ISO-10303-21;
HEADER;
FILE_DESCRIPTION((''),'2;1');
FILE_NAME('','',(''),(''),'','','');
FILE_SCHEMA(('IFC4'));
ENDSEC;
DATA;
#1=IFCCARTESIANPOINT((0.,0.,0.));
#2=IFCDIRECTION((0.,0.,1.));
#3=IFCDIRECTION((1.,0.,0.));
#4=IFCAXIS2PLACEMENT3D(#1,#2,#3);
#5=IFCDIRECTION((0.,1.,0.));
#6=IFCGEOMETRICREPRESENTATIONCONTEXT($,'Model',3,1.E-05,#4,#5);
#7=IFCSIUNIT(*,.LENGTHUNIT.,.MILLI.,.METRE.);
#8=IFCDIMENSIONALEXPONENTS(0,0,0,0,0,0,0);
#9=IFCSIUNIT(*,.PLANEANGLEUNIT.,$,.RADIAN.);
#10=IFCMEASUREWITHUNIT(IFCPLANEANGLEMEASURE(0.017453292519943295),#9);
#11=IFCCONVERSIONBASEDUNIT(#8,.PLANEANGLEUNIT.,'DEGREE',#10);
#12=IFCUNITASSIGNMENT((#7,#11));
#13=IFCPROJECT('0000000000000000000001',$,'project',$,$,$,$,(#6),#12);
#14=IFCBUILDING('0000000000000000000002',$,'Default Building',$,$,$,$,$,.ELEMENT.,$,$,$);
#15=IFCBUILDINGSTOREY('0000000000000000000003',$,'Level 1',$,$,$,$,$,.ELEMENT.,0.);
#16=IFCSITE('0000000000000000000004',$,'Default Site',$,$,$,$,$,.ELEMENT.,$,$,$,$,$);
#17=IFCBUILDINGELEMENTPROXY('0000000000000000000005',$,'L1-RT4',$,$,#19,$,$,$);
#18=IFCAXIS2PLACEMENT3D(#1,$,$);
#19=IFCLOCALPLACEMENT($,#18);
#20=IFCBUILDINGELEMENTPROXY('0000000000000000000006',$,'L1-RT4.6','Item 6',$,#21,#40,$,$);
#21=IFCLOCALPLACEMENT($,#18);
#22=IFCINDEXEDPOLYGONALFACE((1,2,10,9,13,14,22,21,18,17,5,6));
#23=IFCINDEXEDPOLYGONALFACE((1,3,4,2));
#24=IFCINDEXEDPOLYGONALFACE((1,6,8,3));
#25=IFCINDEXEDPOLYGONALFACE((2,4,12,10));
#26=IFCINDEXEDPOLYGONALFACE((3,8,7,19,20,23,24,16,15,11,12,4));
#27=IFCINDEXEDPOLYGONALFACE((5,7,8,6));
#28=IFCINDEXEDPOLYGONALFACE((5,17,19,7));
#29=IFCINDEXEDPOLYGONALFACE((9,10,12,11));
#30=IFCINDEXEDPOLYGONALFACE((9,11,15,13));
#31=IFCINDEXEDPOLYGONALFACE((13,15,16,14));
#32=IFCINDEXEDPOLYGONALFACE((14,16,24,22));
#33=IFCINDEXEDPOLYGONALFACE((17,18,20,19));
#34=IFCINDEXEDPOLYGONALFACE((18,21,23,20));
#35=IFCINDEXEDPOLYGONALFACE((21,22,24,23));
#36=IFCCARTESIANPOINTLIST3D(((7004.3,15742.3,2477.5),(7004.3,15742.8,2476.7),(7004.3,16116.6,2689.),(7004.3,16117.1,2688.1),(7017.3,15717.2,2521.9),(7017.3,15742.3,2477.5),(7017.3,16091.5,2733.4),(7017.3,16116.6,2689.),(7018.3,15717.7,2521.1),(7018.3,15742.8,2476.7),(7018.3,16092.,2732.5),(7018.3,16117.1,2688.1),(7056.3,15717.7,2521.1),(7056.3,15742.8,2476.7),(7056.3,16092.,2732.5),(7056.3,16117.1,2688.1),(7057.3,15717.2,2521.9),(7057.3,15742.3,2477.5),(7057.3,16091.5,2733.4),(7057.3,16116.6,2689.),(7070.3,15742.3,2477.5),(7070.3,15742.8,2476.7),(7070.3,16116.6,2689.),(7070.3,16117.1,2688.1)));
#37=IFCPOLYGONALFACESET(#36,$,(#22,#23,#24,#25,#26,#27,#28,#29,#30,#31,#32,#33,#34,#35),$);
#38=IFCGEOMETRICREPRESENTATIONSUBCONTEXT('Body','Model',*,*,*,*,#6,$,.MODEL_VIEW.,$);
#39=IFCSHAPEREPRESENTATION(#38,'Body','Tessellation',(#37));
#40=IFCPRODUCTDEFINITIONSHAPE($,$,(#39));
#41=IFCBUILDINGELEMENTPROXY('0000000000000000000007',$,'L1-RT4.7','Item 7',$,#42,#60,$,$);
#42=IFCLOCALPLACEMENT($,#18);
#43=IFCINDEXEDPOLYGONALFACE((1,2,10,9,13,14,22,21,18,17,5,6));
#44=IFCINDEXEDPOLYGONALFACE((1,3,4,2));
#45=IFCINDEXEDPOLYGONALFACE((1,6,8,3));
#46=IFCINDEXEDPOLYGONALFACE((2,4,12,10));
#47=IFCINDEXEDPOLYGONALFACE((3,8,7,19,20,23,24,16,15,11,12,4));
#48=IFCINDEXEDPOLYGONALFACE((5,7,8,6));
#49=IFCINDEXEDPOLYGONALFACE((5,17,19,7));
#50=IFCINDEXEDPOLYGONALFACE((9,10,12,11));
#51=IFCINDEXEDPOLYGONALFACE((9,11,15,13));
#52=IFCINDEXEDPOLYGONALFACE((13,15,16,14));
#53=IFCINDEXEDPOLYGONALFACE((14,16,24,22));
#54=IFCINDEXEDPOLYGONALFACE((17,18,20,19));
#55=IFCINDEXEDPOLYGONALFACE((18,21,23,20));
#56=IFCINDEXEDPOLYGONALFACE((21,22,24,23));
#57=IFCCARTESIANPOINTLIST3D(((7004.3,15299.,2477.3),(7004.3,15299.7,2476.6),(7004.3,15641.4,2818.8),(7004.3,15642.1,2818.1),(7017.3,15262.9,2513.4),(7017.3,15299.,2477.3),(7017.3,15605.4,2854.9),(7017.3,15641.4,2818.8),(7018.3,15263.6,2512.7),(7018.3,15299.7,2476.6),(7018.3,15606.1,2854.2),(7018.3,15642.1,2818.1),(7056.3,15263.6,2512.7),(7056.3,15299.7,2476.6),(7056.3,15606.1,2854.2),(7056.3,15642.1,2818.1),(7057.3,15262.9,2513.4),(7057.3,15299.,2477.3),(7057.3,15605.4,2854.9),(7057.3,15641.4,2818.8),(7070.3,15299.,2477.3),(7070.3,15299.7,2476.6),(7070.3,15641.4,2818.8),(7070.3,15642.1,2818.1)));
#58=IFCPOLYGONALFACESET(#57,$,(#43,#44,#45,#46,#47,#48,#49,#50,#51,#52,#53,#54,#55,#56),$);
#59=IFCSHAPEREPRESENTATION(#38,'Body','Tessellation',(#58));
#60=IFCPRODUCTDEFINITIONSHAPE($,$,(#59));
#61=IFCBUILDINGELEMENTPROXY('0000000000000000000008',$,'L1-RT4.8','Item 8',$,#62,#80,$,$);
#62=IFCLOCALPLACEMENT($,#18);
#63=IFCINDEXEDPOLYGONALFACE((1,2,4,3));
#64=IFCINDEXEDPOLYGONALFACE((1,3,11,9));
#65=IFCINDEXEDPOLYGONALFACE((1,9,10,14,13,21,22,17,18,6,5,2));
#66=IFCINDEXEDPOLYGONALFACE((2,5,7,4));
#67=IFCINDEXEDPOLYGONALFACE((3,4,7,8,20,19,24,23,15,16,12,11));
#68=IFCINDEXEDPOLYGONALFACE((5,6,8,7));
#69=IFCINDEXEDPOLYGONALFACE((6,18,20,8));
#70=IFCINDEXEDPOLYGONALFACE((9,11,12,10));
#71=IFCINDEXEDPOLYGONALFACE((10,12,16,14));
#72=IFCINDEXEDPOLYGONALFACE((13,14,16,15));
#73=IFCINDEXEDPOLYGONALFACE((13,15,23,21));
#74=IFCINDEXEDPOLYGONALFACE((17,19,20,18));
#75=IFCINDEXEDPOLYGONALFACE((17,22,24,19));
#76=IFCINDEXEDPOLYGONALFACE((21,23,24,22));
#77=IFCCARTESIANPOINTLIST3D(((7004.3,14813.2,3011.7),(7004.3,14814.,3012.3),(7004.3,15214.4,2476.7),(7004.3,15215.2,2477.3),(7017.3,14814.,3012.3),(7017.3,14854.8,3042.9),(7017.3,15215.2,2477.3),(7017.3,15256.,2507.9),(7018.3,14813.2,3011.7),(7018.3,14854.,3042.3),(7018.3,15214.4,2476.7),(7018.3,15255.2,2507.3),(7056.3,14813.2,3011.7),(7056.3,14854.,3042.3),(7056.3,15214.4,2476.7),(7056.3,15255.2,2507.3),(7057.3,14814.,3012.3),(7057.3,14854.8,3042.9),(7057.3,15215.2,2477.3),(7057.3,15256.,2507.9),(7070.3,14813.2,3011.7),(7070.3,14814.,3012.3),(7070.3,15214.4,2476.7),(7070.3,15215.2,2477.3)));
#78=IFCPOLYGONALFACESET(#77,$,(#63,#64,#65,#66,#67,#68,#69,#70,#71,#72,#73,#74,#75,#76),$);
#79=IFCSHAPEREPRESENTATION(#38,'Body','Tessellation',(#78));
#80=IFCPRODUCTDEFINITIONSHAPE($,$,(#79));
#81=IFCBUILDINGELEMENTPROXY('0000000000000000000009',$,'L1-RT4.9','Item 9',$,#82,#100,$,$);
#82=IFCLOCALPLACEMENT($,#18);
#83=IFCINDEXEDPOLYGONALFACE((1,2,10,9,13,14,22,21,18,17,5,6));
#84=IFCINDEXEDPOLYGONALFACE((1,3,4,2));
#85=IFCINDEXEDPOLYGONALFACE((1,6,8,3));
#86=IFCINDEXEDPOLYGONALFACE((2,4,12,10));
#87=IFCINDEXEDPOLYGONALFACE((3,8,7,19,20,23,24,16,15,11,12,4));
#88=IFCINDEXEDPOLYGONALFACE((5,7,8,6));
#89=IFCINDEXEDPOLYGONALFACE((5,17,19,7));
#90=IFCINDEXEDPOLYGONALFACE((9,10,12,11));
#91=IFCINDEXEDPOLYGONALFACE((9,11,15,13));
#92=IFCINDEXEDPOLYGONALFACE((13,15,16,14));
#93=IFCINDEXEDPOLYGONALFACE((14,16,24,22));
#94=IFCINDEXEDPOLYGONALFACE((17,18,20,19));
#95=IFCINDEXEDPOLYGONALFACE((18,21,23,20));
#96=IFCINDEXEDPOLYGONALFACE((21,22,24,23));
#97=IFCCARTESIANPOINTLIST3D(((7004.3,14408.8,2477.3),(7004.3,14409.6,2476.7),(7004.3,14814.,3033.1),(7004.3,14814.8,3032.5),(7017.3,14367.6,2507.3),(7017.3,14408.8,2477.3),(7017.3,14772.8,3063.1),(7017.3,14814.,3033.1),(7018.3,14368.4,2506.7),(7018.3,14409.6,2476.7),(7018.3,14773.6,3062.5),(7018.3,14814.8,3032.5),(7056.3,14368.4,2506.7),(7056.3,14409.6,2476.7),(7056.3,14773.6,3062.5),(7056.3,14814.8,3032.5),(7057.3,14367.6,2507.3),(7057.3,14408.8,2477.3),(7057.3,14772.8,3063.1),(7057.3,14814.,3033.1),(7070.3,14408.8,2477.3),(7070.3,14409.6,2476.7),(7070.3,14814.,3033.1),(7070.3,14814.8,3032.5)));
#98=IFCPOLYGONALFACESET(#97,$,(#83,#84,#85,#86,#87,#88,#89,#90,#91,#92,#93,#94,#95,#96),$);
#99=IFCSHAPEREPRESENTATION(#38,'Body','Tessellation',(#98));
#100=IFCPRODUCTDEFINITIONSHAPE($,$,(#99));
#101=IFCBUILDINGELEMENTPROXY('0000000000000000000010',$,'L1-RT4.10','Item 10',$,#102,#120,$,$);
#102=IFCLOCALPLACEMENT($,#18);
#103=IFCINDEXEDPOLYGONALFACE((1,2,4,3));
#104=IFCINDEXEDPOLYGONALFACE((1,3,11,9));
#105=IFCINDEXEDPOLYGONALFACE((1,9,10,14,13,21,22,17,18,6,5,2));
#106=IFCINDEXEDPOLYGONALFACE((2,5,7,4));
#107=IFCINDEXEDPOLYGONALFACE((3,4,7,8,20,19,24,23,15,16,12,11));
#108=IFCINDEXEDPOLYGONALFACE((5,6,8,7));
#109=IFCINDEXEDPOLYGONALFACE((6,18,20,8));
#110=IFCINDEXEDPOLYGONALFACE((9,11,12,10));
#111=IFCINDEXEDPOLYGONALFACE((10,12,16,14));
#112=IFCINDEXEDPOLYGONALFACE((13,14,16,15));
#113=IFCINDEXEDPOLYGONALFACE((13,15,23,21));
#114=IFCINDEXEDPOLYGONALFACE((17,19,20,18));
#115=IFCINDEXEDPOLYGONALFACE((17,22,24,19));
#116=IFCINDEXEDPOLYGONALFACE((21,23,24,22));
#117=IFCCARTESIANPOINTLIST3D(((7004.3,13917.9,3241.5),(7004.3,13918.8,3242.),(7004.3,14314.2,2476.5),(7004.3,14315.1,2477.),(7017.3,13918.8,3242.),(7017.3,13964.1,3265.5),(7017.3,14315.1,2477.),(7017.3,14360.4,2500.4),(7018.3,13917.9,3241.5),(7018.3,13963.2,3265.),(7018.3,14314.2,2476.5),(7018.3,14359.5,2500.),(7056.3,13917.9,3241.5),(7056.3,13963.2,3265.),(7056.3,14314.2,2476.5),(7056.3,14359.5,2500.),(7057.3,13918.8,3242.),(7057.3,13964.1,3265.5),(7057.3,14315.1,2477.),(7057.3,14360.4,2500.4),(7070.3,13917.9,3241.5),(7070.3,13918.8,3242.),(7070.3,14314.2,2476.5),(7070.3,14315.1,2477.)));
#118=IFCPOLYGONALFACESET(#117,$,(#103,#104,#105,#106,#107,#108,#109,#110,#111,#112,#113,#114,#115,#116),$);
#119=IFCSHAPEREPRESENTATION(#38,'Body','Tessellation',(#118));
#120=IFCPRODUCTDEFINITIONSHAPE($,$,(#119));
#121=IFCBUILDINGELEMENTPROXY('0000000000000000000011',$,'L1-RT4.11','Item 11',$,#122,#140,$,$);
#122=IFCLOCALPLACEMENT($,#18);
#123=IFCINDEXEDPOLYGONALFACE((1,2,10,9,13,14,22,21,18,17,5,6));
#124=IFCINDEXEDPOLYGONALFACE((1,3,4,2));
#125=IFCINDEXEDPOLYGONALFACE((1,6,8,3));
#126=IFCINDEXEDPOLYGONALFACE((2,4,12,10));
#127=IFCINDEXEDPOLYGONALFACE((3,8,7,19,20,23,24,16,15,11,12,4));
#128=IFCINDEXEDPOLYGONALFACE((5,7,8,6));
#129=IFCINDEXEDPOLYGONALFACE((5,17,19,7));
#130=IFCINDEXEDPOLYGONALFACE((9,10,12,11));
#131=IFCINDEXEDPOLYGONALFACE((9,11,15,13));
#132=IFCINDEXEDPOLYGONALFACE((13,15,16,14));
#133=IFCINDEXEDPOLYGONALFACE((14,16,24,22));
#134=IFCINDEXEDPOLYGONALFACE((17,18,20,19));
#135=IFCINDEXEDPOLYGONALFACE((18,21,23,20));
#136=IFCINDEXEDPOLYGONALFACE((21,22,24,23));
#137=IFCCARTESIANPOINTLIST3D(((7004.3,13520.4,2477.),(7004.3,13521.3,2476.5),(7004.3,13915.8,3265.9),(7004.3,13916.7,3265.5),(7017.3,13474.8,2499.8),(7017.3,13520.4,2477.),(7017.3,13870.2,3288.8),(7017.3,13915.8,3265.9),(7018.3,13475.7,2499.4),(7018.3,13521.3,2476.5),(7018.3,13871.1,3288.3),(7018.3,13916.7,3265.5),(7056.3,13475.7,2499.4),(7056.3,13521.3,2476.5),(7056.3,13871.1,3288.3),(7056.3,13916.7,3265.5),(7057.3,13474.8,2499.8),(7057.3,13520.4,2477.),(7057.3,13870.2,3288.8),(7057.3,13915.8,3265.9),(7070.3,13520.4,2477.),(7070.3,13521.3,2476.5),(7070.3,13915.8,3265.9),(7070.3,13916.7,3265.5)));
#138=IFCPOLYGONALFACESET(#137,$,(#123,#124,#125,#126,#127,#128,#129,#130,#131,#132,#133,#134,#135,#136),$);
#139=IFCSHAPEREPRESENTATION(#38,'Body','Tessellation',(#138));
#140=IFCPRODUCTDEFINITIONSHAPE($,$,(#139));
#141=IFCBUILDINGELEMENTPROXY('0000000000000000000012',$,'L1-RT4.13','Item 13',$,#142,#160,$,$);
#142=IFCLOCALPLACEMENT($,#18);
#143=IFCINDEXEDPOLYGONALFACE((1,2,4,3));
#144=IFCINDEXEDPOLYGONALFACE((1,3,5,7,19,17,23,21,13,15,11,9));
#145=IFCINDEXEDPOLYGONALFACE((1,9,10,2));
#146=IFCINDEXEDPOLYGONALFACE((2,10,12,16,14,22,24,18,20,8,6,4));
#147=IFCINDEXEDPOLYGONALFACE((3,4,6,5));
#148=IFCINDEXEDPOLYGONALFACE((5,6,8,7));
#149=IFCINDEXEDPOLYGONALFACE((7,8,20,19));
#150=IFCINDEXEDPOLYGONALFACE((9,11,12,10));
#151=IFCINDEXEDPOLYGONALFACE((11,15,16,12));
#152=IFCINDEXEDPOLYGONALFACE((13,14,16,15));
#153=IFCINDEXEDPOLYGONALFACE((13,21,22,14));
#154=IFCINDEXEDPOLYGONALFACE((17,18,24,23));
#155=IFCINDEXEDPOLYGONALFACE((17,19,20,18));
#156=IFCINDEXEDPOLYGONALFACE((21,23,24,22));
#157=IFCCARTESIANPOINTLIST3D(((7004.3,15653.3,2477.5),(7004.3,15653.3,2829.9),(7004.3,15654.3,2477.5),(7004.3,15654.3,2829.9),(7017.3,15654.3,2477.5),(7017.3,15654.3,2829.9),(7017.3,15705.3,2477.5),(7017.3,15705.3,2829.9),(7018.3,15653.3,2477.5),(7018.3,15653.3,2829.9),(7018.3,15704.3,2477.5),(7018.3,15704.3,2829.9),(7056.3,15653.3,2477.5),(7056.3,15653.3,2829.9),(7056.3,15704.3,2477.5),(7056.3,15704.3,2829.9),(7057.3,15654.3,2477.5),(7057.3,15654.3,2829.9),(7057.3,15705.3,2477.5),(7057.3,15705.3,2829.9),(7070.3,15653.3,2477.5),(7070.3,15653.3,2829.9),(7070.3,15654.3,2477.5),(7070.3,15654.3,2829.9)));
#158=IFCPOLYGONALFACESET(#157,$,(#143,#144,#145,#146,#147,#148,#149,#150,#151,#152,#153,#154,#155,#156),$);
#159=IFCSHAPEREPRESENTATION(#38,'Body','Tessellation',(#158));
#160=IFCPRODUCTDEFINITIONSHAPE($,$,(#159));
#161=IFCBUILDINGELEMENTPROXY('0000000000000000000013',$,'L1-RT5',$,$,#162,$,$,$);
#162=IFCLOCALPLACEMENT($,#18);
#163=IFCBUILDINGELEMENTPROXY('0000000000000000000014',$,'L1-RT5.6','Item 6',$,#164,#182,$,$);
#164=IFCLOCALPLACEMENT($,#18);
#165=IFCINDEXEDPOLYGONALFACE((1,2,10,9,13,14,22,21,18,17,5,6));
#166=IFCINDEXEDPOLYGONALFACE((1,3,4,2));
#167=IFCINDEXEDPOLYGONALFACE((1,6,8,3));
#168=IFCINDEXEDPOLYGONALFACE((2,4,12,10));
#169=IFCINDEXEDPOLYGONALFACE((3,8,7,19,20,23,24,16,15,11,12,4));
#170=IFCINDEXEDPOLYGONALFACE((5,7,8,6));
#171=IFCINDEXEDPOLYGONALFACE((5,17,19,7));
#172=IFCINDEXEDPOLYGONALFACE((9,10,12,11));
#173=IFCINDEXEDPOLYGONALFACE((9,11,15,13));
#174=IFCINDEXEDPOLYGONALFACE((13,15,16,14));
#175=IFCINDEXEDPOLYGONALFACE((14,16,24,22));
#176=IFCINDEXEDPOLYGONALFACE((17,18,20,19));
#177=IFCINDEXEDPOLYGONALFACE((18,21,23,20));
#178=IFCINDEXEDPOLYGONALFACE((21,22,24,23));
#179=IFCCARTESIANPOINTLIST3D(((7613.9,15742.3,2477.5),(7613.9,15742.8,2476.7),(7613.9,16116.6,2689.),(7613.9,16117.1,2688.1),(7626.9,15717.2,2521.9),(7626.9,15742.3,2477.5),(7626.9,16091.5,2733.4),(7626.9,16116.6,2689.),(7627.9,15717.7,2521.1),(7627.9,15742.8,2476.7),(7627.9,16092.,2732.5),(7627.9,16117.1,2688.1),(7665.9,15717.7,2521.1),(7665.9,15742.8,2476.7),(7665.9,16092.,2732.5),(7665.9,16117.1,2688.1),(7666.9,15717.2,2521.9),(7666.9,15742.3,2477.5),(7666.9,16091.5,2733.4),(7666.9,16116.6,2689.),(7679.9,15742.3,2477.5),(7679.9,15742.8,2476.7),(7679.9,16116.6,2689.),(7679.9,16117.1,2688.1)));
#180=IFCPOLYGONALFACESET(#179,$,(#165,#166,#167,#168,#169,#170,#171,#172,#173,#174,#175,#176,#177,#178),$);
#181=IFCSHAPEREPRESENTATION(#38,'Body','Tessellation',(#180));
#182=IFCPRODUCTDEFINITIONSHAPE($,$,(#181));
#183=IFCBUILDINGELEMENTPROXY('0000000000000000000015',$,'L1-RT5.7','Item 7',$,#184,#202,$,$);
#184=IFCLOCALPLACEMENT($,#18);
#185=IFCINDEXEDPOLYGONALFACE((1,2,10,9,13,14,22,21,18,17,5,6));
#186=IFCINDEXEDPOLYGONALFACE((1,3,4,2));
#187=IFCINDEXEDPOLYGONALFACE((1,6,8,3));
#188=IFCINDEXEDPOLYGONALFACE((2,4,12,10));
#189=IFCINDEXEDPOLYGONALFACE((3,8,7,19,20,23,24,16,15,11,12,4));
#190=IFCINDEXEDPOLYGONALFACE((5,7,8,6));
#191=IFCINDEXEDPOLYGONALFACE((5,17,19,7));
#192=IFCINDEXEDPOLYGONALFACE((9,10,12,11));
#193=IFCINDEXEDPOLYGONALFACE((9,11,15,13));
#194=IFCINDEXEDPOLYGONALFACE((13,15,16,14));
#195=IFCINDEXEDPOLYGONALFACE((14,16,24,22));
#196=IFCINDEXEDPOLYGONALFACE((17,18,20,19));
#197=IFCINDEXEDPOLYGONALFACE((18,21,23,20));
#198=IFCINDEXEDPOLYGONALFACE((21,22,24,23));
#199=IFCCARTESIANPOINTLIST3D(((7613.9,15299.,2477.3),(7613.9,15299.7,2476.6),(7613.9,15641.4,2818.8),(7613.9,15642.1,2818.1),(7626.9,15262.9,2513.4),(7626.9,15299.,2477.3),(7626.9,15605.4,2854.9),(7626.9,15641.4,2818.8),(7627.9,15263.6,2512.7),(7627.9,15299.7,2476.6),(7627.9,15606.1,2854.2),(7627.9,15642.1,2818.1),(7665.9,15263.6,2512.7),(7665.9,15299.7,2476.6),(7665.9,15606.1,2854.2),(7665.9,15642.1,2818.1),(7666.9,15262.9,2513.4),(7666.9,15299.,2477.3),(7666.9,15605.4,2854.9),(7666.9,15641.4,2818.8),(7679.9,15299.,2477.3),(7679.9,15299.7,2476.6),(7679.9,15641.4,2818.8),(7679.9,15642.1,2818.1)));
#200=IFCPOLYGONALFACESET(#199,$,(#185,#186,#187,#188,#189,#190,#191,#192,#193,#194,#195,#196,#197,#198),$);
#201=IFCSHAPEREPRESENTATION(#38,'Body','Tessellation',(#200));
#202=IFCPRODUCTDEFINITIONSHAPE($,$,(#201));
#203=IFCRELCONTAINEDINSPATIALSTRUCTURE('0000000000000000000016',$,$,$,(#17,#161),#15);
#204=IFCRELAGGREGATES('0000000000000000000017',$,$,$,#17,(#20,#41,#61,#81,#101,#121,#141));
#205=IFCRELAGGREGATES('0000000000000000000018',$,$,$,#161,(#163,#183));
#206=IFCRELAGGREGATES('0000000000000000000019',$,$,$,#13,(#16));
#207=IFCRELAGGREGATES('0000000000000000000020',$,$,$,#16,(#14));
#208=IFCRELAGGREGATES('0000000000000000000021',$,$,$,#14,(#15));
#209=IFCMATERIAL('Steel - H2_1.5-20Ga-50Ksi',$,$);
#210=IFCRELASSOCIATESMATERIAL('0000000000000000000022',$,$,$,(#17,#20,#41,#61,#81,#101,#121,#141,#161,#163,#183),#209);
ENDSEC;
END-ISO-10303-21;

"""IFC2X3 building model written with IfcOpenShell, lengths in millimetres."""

from ifc_helpers import new_model, entity, si_unit, converted_unit, direction, frame, origin, origin_with_axes, place, context, subcontext, project, spatial, polyline, outline, extrude, material, element, aggregate, save


model = new_model("IFC2X3")

# Units and contexts
model_context = context("Model", 3, precision=1e-05, world=origin_with_axes(), true_north=direction((0.0, 1.0, 0.0)))
body_context = subcontext(model_context, "Body", "Model", "MODEL_VIEW")
ifc_project = project(units=[si_unit("LENGTHUNIT", "METRE", prefix="MILLI"), converted_unit("PLANEANGLEUNIT", "DEGREE", entity("IfcPlaneAngleMeasure", 0.017453292519943295), si_unit("PLANEANGLEUNIT", "RADIAN"), dimensions=[0, 0, 0, 0, 0, 0, 0])], contexts=[model_context])

# Site, building, storey
site = spatial("IfcSite", under=ifc_project, Name="Default Site", CompositionType="ELEMENT")
building = spatial("IfcBuilding", under=site, Name="Default Building", CompositionType="ELEMENT")
storey = spatial("IfcBuildingStorey", under=building, Name="Level 1", CompositionType="ELEMENT", Elevation=0.0)

# Building element proxies
ifc_material = material(Name="Steel - H2_1.5-20Ga-50Ksi")
proxy_1 = element("IfcBuildingElementProxy", 1, inside=storey, material=ifc_material, Name="L1-RT4")
proxy_2_placement = place(None, frame((7004.3, 16117.1, 2688.1), z_axis=(0.0, -0.871, -0.492), x_axis=(40.0, 0.0, 0.0)))
proxy_2 = element("IfcBuildingElementProxy", 2, at=proxy_2_placement, material=ifc_material, Name="L1-RT4.6", Description="Item 6", context=body_context, shape_type="SweptSolid", body=[
    extrude(outline(polyline([(0.0, 0.0), (14.0, 0.0), (14.0, 51.0), (52.0, 51.0), (52.0, 0.0), (66.0, 0.0), (66.0, 1.0), (53.0, 1.0), (53.0, 52.0), (13.0, 52.0), (13.0, 1.0), (0.0, 1.0), (0.0, 0.0)])), origin(), (0.0, 0.0, 1.0), 429.9),
])
proxy_3_placement = place(None, frame((7004.3, 15642.1, 2818.1), z_axis=(0.0, -0.708, -0.706), x_axis=(40.0, 0.0, 0.0)))
proxy_3 = element("IfcBuildingElementProxy", 3, at=proxy_3_placement, material=ifc_material, Name="L1-RT4.7", Description="Item 7", context=body_context, shape_type="SweptSolid", body=[
    extrude(outline(polyline([(0.0, 0.0), (14.0, 0.0), (14.0, 51.0), (52.0, 51.0), (52.0, 0.0), (66.0, 0.0), (66.0, 1.0), (53.0, 1.0), (53.0, 52.0), (13.0, 52.0), (13.0, 1.0), (0.0, 1.0), (0.0, 0.0)])), origin(), (0.0, 0.0, 1.0), 483.6),
])
proxy_4_placement = place(None, frame((7004.3, 15214.4, 2476.7), z_axis=(0.0, -0.6, 0.8), x_axis=(40.0, 0.0, 0.0)))
proxy_4 = element("IfcBuildingElementProxy", 4, at=proxy_4_placement, material=ifc_material, Name="L1-RT4.8", Description="Item 8", context=body_context, shape_type="SweptSolid", body=[
    extrude(outline(polyline([(0.0, 0.0), (14.0, 0.0), (14.0, 51.0), (52.0, 51.0), (52.0, 0.0), (66.0, 0.0), (66.0, 1.0), (53.0, 1.0), (53.0, 52.0), (13.0, 52.0), (13.0, 1.0), (0.0, 1.0), (0.0, 0.0)])), origin(), (0.0, 0.0, 1.0), 668.7),
])
proxy_5_placement = place(None, frame((7004.3, 14814.8, 3032.5), z_axis=(0.0, -0.589, -0.808), x_axis=(40.0, 0.0, 0.0)))
proxy_5 = element("IfcBuildingElementProxy", 5, at=proxy_5_placement, material=ifc_material, Name="L1-RT4.9", Description="Item 9", context=body_context, shape_type="SweptSolid", body=[
    extrude(outline(polyline([(0.0, 0.0), (14.0, 0.0), (14.0, 51.0), (52.0, 51.0), (52.0, 0.0), (66.0, 0.0), (66.0, 1.0), (53.0, 1.0), (53.0, 52.0), (13.0, 52.0), (13.0, 1.0), (0.0, 1.0), (0.0, 0.0)])), origin(), (0.0, 0.0, 1.0), 687.8),
])
proxy_6_placement = place(None, frame((7004.3, 14314.2, 2476.5), z_axis=(0.0, -0.46, 0.888), x_axis=(40.0, 0.0, 0.0)))
proxy_6 = element("IfcBuildingElementProxy", 6, at=proxy_6_placement, material=ifc_material, Name="L1-RT4.10", Description="Item 10", context=body_context, shape_type="SweptSolid", body=[
    extrude(outline(polyline([(0.0, 0.0), (14.0, 0.0), (14.0, 51.0), (52.0, 51.0), (52.0, 0.0), (66.0, 0.0), (66.0, 1.0), (53.0, 1.0), (53.0, 52.0), (13.0, 52.0), (13.0, 1.0), (0.0, 1.0), (0.0, 0.0)])), origin(), (0.0, 0.0, 1.0), 861.6),
])
proxy_7_placement = place(None, frame((7004.3, 13916.7, 3265.5), z_axis=(0.0, -0.448, -0.894), x_axis=(40.0, 0.0, 0.0)))
proxy_7 = element("IfcBuildingElementProxy", 7, at=proxy_7_placement, material=ifc_material, Name="L1-RT4.11", Description="Item 11", context=body_context, shape_type="SweptSolid", body=[
    extrude(outline(polyline([(0.0, 0.0), (14.0, 0.0), (14.0, 51.0), (52.0, 51.0), (52.0, 0.0), (66.0, 0.0), (66.0, 1.0), (53.0, 1.0), (53.0, 52.0), (13.0, 52.0), (13.0, 1.0), (0.0, 1.0), (0.0, 0.0)])), origin(), (0.0, 0.0, 1.0), 882.5),
])
proxy_8_placement = place(None, frame((7004.3, 15653.3, 2477.5), z_axis=(0.0, 0.0, 1.0), x_axis=(40.0, 0.0, 0.0)))
proxy_8 = element("IfcBuildingElementProxy", 8, at=proxy_8_placement, material=ifc_material, Name="L1-RT4.13", Description="Item 13", context=body_context, shape_type="SweptSolid", body=[
    extrude(outline(polyline([(0.0, 0.0), (14.0, 0.0), (14.0, 51.0), (52.0, 51.0), (52.0, 0.0), (66.0, 0.0), (66.0, 1.0), (53.0, 1.0), (53.0, 52.0), (13.0, 52.0), (13.0, 1.0), (0.0, 1.0), (0.0, 0.0)])), origin(), (0.0, 0.0, 1.0), 352.4),
])
aggregate(proxy_1, [proxy_2, proxy_3, proxy_4, proxy_5, proxy_6, proxy_7, proxy_8])
proxy_9 = element("IfcBuildingElementProxy", 9, inside=storey, material=ifc_material, Name="L1-RT5")
proxy_10_placement = place(None, frame((7613.9, 16117.1, 2688.1), z_axis=(0.0, -0.871, -0.492), x_axis=(40.0, 0.0, 0.0)))
proxy_10 = element("IfcBuildingElementProxy", 10, at=proxy_10_placement, material=ifc_material, Name="L1-RT5.6", Description="Item 6", context=body_context, shape_type="SweptSolid", body=[
    extrude(outline(polyline([(0.0, 0.0), (14.0, 0.0), (14.0, 51.0), (52.0, 51.0), (52.0, 0.0), (66.0, 0.0), (66.0, 1.0), (53.0, 1.0), (53.0, 52.0), (13.0, 52.0), (13.0, 1.0), (0.0, 1.0), (0.0, 0.0)])), origin(), (0.0, 0.0, 1.0), 429.9),
])
proxy_11_placement = place(None, frame((7613.9, 15642.1, 2818.1), z_axis=(0.0, -0.708, -0.706), x_axis=(40.0, 0.0, 0.0)))
proxy_11 = element("IfcBuildingElementProxy", 11, at=proxy_11_placement, material=ifc_material, Name="L1-RT5.7", Description="Item 7", context=body_context, shape_type="SweptSolid", body=[
    extrude(outline(polyline([(0.0, 0.0), (14.0, 0.0), (14.0, 51.0), (52.0, 51.0), (52.0, 0.0), (66.0, 0.0), (66.0, 1.0), (53.0, 1.0), (53.0, 52.0), (13.0, 52.0), (13.0, 1.0), (0.0, 1.0), (0.0, 0.0)])), origin(), (0.0, 0.0, 1.0), 483.6),
])
aggregate(proxy_9, [proxy_10, proxy_11])

save(model, "model.ifc")
